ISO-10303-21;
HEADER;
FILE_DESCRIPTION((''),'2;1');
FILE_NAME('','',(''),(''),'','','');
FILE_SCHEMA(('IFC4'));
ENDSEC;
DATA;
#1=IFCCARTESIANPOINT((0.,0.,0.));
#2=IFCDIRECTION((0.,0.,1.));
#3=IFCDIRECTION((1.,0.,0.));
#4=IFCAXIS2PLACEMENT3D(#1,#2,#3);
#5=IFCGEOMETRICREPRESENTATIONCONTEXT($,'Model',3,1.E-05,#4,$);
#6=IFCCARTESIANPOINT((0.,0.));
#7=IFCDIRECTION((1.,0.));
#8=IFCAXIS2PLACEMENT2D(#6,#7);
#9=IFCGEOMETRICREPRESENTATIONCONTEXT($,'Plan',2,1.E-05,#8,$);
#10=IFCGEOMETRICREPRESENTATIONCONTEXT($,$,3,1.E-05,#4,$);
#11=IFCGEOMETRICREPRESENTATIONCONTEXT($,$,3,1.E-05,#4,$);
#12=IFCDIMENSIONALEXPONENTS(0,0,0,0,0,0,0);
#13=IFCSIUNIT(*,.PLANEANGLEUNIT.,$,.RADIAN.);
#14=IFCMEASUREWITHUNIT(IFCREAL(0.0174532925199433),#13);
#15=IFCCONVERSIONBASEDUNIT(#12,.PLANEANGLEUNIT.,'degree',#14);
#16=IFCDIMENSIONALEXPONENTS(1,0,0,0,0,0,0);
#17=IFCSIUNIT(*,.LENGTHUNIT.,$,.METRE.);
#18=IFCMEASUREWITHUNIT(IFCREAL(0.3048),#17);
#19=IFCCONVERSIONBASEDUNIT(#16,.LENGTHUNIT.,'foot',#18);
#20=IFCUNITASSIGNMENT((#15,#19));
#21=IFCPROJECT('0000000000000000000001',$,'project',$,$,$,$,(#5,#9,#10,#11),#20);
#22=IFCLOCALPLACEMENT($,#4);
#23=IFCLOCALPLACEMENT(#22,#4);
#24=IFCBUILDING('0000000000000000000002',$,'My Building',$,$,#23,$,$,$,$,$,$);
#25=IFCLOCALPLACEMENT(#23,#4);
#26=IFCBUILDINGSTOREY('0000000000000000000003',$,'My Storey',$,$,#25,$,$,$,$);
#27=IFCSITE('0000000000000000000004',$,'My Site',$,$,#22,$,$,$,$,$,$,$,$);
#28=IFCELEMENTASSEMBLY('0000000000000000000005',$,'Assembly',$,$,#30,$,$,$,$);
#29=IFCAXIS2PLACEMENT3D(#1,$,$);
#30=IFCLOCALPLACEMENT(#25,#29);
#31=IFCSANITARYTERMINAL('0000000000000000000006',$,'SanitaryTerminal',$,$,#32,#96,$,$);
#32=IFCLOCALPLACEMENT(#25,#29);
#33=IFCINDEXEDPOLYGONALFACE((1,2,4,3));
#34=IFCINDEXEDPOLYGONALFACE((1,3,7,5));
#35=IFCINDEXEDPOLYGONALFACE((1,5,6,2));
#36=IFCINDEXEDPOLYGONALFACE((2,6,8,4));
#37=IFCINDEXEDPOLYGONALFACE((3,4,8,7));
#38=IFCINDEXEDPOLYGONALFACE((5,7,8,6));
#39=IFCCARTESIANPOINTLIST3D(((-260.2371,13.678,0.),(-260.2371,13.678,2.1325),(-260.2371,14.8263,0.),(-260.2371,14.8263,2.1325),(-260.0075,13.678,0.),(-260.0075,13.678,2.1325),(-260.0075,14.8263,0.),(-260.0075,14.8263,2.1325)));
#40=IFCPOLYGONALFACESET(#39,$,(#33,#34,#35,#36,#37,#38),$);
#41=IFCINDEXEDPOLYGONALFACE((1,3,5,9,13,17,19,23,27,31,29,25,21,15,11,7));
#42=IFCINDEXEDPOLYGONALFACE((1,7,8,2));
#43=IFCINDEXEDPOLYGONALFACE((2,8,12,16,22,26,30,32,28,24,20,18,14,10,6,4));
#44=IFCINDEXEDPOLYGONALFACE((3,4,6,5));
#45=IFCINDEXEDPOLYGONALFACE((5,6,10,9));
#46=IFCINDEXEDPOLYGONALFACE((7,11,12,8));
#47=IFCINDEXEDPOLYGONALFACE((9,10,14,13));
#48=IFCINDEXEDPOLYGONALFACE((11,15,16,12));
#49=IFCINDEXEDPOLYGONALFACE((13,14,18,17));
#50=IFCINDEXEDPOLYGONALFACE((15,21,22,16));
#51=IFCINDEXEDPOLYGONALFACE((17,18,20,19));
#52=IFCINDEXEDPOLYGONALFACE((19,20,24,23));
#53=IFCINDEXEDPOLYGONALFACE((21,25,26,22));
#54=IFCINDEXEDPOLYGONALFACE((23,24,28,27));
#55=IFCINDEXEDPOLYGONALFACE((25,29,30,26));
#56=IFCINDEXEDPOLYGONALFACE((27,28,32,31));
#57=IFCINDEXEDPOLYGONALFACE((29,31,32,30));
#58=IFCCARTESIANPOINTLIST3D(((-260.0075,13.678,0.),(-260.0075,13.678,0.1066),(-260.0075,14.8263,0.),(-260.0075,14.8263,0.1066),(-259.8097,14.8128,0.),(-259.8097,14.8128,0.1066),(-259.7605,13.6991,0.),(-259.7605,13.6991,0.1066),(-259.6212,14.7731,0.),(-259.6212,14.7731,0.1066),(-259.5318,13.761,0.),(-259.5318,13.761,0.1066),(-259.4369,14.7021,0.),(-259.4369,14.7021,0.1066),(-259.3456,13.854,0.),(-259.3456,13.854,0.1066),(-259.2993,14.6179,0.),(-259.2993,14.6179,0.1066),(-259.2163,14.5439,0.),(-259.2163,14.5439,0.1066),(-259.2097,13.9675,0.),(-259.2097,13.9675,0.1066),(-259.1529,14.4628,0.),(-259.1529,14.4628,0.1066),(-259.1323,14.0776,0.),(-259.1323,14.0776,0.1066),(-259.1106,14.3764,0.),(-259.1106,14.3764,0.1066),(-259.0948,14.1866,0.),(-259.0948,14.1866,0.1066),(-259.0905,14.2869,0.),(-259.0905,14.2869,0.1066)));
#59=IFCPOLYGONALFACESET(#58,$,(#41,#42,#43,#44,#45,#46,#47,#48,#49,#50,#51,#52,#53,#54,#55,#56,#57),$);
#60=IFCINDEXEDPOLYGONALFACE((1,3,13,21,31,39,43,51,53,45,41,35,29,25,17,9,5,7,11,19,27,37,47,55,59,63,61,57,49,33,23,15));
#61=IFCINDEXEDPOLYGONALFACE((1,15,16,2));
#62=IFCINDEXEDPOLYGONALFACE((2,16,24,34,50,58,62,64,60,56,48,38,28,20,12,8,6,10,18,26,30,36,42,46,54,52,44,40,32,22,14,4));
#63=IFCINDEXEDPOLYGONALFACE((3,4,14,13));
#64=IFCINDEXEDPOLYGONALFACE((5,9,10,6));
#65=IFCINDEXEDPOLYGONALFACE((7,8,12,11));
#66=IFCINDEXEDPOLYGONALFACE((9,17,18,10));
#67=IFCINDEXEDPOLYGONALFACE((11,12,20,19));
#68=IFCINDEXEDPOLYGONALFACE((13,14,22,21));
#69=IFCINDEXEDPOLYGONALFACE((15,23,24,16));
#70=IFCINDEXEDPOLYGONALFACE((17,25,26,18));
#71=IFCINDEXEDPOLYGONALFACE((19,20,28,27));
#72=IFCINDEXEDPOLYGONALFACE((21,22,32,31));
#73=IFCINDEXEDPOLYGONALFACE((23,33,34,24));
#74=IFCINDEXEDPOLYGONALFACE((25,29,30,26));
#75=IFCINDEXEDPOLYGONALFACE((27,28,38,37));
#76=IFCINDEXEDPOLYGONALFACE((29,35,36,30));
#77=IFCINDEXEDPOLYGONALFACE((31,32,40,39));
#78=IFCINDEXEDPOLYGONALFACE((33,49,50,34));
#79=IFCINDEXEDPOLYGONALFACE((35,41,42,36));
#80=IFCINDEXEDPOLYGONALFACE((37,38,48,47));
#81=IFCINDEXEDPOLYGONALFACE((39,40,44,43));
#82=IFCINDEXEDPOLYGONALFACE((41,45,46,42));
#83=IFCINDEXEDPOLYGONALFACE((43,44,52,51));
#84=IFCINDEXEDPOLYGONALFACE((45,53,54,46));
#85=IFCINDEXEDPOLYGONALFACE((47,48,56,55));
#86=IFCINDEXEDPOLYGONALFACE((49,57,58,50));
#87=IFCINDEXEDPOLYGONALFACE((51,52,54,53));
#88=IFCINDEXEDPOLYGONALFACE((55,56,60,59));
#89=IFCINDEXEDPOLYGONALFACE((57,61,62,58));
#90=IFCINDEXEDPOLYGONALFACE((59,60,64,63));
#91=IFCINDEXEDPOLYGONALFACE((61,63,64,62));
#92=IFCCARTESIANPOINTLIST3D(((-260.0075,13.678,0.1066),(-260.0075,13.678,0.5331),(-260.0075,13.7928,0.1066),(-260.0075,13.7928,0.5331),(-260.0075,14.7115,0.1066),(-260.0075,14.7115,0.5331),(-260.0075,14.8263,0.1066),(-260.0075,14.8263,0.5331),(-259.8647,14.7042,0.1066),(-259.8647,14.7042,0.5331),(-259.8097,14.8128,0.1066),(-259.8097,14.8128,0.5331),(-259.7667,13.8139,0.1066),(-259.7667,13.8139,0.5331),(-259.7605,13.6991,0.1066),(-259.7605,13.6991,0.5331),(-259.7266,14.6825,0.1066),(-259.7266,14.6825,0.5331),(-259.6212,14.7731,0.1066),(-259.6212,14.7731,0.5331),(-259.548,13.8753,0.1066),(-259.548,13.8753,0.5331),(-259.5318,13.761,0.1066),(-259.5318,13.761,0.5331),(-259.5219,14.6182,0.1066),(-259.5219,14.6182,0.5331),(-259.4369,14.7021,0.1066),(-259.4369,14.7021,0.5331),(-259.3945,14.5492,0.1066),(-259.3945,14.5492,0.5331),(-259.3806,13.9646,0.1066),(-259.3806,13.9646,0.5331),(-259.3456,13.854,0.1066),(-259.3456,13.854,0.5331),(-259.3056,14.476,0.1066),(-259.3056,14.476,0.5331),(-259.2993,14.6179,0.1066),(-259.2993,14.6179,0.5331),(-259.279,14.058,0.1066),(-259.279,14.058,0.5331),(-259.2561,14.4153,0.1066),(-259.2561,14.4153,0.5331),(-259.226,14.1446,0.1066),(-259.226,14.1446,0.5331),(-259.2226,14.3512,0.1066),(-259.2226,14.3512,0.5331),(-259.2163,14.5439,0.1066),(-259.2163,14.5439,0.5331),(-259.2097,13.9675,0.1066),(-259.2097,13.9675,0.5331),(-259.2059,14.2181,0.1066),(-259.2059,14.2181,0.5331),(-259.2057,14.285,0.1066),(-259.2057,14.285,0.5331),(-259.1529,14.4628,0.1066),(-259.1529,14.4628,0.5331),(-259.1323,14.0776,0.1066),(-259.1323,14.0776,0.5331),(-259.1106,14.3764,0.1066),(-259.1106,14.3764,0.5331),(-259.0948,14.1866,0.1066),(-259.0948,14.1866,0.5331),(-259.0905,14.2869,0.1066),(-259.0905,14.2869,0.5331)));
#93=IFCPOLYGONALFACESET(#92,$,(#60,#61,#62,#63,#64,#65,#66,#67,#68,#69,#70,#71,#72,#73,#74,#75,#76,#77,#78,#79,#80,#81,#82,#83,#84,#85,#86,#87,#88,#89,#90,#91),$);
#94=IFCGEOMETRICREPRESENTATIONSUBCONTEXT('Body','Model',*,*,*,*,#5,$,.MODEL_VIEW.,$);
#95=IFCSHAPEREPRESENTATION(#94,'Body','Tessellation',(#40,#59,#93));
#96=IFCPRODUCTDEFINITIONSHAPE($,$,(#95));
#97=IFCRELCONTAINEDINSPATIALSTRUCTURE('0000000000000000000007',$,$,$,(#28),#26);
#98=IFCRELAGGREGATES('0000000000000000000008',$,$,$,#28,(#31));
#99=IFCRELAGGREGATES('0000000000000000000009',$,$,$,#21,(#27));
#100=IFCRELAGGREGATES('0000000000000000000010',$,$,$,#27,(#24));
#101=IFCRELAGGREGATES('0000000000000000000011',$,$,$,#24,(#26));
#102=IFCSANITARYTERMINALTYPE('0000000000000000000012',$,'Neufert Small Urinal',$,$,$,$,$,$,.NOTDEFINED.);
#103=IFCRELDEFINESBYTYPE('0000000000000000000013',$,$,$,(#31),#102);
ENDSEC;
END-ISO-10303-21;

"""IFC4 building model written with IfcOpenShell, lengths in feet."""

from ifc_helpers import new_model, entity, si_unit, converted_unit, point, frame, frame_2d, origin_with_axes, origin_2d_with_axis, place, context, subcontext, project, spatial, line, indexed_curve, ellipse_curve, trimmed, outline, extrude, shape, source, transform, mapped, type_object, type_shapes, element, aggregate, save


model = new_model("IFC4")

# Units and contexts
model_context = context("Model", 3, precision=1e-05, world=origin_with_axes())
plan_context = context("Plan", 2, precision=1e-05, world=origin_2d_with_axis())
context_of_model_1 = context(None, 3, precision=1e-05, world=origin_with_axes())
context_of_model_2 = context(None, 3, precision=1e-05, world=origin_with_axes())
body_context_1 = subcontext(model_context, "Body", "Model", "MODEL_VIEW")
body_context_2 = subcontext(plan_context, "Body", "Plan", "PLAN_VIEW")
ifc_project = project(units=[converted_unit("PLANEANGLEUNIT", "degree", entity("IfcReal", 0.0174532925199433), si_unit("PLANEANGLEUNIT", "RADIAN"), dimensions=[0, 0, 0, 0, 0, 0, 0]), converted_unit("LENGTHUNIT", "foot", entity("IfcReal", 0.3048), si_unit("LENGTHUNIT", "METRE"), dimensions=[1, 0, 0, 0, 0, 0, 0])], contexts=[model_context, plan_context, context_of_model_1, context_of_model_2])

# Site, building, storey
site_placement = place(None, origin_with_axes())
site = spatial("IfcSite", under=ifc_project, at=site_placement, Name="My Site")
building_placement = place(site_placement, origin_with_axes())
building = spatial("IfcBuilding", under=site, at=building_placement, Name="My Building")
storey_placement = place(building_placement, origin_with_axes())
storey = spatial("IfcBuildingStorey", under=building, at=storey_placement, Name="My Storey")

# Element assembly, sanitary terminal
assembly_placement = place(storey_placement, origin_with_axes())
assembly = element("IfcElementAssembly", 1, at=assembly_placement, inside=storey, Name="Assembly")
sanitary_terminal_type = type_object("IfcSanitaryTerminalType", Name="Neufert Small Urinal", PredefinedType="NOTDEFINED")
shared_shape_1 = source(origin_with_axes(), body_context_1, "Body", "SweptSolid", [
    extrude(outline(indexed_curve([(0.0, 0.0), (1.1483, 0.0), (1.1483, 2.1325), (0.0, 2.1325)], segments=[line(1, 2, 3, 4, 1)])), frame((-0.5741, 0.0, 0.0), z_axis=(0.0, -1.0, 0.0), x_axis=(1.0, 0.0, 0.0)), (0.0, 0.0, 1.0), 0.2297),
    extrude(outline(trimmed(ellipse_curve(frame_2d((0.0, -0.2297), x_axis=(1.0, 0.0)), 0.5741, 0.9186), [point((-0.5741, -0.2297))], [point((0.5741, -0.2297))], True, "CARTESIAN")), origin_with_axes(), (0.0, 0.0, 1.0), 0.1066),
    extrude(outline(trimmed(ellipse_curve(frame_2d((0.0, -0.2297), x_axis=(1.0, 0.0)), 0.5741, 0.9186), [point((-0.5741, -0.2297))], [point((0.5741, -0.2297))], True, "CARTESIAN"), holes=[trimmed(ellipse_curve(frame_2d((0.0, -0.2297), x_axis=(1.0, 0.0)), 0.4593, 0.8038), [point((-0.4593, -0.2297))], [point((0.4593, -0.2297))], True, "CARTESIAN")]), frame((0.0, 0.0, 0.1066), z_axis=(0.0, 0.0, 1.0), x_axis=(1.0, 0.0, 0.0)), (0.0, 0.0, 1.0), 0.4265),
])
shared_shape_2 = source(origin_with_axes(), body_context_2, "Body", "Curve2D", [
    entity("IfcTrimmedCurve", entity("IfcEllipse", entity("IfcAxis2Placement2D", entity("IfcCartesianPoint", [0.0, 0.0]), entity("IfcDirection", [1.0, 0.0])), 0.5741, 1.1483), [entity("IfcCartesianPoint", [-0.5741, 0.0])], [entity("IfcCartesianPoint", [0.5741, 0.0])], True, "CARTESIAN"),
    entity("IfcIndexedPolyCurve", entity("IfcCartesianPointList2D", [[0.5741, 0.0], [-0.5741, 0.0]])),
    entity("IfcCircle", entity("IfcAxis2Placement2D", entity("IfcCartesianPoint", [0.0, -0.2871])), 0.0574),
    entity("IfcTrimmedCurve", entity("IfcEllipse", entity("IfcAxis2Placement2D", entity("IfcCartesianPoint", [0.0, -0.2297]), entity("IfcDirection", [1.0, 0.0])), 0.4593, 0.8038), [entity("IfcCartesianPoint", [-0.4593, -0.2297])], [entity("IfcCartesianPoint", [0.4593, -0.2297])], True, "CARTESIAN"),
    entity("IfcIndexedPolyCurve", entity("IfcCartesianPointList2D", [[-0.3445, -0.1148], [-0.3445, -0.1148], [-0.4593, -0.2297]]), [entity("IfcArcIndex", [1, 2, 3])]),
    entity("IfcIndexedPolyCurve", entity("IfcCartesianPointList2D", [[-0.3445, -0.1148], [0.3445, -0.1148]])),
    entity("IfcIndexedPolyCurve", entity("IfcCartesianPointList2D", [[0.3445, -0.1148], [0.3445, -0.1148], [0.4593, -0.2297]]), [entity("IfcArcIndex", [1, 2, 3])]),
])
type_shapes(sanitary_terminal_type, [shared_shape_1, shared_shape_2])
sanitary_terminal_placement = place(assembly_placement, frame((-260.2371, 14.2521, 0.0), z_axis=(0.0, 0.0, 1.0), x_axis=(0.0, 1.0, 0.0)))
sanitary_terminal = element("IfcSanitaryTerminal", 2, at=sanitary_terminal_placement, type_object=sanitary_terminal_type, Name="SanitaryTerminal", shapes=[
    shape(body_context_1, "Body", "MappedRepresentation", [mapped(shared_shape_1, transform((0.0, 0.0, 0.0), x_axis=(1.0, 0.0, 0.0), y_axis=(0.0, 1.0, 0.0), z_axis=(0.0, 0.0, 1.0), scale=1.0))]),
    shape(body_context_2, "Body", "MappedRepresentation", [mapped(shared_shape_2, transform((0.0, 0.0, 0.0), x_axis=(1.0, 0.0, 0.0), y_axis=(0.0, 1.0, 0.0), z_axis=(0.0, 0.0, 1.0), scale=1.0))]),
])
aggregate(assembly, [sanitary_terminal])

save(model, "model.ifc")
